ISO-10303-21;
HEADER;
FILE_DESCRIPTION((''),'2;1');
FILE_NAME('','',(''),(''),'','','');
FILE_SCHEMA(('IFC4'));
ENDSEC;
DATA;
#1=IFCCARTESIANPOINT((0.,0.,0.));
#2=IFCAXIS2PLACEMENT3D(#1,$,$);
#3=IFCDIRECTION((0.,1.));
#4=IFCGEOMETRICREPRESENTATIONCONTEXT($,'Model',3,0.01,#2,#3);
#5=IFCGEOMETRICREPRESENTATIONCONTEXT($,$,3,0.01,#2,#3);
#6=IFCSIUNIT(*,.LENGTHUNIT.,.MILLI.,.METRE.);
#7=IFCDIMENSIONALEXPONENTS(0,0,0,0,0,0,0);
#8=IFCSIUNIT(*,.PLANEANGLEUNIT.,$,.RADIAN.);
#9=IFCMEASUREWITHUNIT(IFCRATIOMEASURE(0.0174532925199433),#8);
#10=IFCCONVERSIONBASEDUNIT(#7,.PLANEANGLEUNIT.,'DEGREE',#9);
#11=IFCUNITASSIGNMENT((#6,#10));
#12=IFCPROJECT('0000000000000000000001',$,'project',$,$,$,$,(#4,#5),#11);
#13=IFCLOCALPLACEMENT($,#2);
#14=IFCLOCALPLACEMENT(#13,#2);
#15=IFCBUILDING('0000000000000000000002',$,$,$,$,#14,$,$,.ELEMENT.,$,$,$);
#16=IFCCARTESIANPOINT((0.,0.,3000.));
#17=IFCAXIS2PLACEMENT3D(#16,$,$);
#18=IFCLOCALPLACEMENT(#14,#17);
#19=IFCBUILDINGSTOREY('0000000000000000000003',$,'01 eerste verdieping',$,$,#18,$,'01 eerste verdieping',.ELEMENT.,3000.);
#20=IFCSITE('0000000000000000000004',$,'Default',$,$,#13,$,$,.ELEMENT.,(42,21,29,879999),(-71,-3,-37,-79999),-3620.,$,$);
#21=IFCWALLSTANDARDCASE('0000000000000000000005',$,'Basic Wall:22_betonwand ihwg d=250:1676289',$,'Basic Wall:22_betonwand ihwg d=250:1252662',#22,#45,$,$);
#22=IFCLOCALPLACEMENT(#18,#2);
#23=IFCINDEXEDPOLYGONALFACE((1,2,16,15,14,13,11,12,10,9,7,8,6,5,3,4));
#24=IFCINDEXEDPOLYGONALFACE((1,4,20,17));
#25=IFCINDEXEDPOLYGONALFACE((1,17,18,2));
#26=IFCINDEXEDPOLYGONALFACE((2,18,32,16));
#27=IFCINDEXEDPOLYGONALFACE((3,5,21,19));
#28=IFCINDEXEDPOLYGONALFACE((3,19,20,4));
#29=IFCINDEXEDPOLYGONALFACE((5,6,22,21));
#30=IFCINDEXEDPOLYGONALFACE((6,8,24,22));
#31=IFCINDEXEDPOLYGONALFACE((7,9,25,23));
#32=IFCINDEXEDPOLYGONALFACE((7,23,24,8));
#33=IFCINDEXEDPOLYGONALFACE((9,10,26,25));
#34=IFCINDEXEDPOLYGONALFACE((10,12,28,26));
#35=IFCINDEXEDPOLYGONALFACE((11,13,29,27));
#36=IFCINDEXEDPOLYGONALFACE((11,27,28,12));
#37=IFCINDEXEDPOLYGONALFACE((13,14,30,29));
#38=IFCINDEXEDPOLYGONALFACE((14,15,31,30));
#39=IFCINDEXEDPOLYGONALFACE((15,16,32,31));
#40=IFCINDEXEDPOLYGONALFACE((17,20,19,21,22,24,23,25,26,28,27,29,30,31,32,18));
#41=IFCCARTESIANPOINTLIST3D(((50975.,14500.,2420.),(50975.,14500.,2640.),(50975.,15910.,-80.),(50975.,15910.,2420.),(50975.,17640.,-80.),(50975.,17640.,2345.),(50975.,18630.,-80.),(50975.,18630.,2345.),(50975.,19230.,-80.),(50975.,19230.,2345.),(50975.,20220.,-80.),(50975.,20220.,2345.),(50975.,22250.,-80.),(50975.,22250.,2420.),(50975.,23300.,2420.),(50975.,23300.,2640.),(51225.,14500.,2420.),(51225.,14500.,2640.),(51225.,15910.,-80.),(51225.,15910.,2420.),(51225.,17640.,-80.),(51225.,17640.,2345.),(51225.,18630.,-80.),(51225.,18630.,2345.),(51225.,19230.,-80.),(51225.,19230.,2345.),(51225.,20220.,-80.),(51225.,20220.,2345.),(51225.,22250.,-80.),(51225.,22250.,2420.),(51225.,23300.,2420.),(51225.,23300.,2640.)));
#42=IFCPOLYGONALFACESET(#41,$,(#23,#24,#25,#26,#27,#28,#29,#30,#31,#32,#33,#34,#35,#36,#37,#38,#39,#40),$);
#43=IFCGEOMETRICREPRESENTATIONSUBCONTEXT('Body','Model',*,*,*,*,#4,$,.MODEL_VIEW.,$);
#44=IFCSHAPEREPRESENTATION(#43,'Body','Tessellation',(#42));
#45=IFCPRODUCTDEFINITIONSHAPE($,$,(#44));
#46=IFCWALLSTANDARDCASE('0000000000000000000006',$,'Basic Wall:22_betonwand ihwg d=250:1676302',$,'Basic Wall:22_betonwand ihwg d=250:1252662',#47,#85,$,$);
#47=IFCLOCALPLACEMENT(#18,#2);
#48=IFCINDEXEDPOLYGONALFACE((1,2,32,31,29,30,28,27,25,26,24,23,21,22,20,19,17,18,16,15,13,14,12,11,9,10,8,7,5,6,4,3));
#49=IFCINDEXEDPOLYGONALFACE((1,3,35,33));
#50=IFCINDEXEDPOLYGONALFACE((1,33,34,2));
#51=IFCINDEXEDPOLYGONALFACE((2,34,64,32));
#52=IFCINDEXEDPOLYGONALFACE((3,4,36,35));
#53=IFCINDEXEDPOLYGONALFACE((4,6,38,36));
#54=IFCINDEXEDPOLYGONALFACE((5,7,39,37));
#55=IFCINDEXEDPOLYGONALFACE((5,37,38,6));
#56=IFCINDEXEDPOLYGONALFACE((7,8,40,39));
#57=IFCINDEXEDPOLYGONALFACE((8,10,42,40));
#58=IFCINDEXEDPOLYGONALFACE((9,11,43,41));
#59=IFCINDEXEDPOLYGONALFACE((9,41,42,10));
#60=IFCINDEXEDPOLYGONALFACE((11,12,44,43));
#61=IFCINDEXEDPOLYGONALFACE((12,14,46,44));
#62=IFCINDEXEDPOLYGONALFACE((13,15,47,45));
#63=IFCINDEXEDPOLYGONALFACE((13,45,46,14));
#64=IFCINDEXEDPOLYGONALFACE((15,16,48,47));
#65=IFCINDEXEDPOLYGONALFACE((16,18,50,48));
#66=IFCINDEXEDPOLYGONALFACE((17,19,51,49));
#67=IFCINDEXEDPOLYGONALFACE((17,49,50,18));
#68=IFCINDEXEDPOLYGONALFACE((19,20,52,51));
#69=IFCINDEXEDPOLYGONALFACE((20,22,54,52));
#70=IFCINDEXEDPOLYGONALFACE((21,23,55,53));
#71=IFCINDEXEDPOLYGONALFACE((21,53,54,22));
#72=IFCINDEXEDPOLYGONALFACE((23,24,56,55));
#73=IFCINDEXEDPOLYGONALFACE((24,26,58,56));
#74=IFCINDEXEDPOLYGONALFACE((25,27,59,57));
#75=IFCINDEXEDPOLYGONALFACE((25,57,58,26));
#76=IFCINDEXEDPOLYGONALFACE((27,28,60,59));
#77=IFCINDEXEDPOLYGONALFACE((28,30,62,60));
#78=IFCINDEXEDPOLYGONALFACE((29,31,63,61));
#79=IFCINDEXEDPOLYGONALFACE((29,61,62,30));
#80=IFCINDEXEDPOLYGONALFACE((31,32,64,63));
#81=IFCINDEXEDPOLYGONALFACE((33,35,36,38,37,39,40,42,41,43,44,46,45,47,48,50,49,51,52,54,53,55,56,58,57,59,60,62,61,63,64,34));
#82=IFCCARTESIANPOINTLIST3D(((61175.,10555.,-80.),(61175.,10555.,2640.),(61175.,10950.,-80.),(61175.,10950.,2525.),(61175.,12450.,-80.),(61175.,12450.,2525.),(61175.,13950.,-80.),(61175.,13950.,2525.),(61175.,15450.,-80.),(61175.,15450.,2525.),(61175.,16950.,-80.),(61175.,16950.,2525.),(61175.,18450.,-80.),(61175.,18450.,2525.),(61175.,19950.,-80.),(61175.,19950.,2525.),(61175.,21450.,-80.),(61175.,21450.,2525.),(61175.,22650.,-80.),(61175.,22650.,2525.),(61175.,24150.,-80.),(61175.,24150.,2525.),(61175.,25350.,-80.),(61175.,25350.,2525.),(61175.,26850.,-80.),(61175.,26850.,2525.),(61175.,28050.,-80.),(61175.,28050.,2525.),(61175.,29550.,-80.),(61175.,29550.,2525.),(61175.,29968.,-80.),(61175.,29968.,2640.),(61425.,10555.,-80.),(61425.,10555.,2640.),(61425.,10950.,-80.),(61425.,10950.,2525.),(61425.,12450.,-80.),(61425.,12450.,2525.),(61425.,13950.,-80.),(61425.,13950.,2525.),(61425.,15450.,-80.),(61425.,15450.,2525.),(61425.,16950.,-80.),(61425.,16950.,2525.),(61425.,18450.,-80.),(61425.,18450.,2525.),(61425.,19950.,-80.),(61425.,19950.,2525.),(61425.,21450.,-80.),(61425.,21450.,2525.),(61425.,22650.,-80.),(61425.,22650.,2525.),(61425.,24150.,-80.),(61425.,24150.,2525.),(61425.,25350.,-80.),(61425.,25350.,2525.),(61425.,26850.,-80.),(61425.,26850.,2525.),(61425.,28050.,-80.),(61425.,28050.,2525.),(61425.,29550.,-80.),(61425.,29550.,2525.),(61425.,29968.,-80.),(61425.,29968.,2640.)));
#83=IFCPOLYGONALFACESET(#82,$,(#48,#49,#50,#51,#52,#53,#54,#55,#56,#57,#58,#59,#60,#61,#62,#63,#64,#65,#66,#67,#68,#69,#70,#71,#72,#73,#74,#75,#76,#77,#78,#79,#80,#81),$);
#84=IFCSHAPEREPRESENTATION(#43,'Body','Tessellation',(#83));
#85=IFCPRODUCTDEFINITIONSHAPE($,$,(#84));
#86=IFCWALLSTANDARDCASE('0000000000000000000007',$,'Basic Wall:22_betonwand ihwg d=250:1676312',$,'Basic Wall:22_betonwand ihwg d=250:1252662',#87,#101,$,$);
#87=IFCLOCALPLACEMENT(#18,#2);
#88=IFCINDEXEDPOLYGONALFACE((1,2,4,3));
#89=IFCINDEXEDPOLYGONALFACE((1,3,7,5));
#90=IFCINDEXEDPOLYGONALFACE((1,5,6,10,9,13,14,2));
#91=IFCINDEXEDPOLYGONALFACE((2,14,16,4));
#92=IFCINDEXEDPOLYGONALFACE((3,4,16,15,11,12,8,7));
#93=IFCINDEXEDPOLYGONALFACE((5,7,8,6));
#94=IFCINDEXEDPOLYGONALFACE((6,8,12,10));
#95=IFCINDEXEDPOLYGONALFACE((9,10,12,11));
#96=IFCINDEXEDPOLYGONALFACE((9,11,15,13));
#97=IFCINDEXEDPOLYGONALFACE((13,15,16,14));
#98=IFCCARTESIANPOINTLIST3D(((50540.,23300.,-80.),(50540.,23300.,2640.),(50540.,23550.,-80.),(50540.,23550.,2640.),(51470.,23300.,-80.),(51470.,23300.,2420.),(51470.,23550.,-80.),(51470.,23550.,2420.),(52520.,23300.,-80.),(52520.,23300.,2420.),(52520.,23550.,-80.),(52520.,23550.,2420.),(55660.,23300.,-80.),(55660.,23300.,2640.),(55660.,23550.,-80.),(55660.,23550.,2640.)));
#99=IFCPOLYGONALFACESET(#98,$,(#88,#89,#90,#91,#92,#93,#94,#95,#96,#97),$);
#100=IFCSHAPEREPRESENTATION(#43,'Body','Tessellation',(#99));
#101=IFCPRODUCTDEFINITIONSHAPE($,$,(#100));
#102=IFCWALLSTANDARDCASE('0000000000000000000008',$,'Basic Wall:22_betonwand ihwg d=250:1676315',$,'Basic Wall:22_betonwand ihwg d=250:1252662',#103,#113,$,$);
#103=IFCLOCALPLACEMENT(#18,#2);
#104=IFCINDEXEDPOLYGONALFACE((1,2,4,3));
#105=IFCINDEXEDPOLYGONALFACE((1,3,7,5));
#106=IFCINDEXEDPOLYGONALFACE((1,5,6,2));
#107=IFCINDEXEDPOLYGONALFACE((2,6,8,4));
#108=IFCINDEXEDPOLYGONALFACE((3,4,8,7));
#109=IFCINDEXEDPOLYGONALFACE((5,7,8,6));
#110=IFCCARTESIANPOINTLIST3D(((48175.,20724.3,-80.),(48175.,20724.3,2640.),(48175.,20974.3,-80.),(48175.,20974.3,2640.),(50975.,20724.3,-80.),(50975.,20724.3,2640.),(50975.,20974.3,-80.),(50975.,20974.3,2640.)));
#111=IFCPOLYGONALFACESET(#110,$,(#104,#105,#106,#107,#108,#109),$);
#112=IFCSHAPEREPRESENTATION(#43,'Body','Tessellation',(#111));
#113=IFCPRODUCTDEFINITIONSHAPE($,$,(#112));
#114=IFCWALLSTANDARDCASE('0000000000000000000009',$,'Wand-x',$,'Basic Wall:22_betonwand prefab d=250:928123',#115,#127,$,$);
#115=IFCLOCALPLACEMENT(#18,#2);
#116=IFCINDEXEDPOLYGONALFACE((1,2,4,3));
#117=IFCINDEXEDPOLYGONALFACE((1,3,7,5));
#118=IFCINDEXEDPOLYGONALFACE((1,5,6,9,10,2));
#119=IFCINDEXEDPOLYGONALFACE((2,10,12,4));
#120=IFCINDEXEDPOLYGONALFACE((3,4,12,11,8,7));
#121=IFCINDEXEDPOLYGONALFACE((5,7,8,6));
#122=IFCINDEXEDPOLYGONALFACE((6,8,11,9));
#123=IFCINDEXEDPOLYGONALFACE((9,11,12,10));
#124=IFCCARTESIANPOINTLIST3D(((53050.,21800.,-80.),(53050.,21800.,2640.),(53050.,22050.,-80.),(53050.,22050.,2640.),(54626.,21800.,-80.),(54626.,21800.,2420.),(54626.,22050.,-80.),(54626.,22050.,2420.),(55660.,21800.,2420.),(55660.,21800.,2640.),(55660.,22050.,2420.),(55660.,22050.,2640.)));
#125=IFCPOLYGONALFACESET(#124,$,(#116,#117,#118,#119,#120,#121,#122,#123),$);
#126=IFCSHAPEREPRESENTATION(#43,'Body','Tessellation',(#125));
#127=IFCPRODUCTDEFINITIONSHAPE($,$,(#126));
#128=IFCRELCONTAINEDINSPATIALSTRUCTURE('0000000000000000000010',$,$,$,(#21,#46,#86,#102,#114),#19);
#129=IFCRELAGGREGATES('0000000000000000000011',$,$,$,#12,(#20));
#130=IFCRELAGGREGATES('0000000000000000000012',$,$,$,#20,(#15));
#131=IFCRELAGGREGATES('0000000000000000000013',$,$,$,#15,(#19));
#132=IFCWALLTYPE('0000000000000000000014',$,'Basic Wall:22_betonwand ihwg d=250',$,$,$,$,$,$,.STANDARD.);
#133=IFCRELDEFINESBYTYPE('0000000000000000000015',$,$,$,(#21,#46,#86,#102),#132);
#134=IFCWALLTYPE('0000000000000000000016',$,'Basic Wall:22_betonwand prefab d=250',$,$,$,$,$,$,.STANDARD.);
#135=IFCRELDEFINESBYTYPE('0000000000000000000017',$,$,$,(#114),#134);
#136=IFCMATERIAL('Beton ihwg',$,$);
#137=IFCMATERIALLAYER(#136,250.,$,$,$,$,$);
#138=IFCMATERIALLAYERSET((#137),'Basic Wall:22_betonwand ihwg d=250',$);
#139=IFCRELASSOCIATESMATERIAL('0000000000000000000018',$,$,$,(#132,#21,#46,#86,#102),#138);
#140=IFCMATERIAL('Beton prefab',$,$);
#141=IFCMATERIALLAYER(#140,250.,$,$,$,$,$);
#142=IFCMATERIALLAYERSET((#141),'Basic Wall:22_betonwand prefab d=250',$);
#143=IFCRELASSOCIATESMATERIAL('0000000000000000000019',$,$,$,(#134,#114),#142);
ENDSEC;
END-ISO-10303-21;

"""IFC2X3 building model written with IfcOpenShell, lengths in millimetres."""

from ifc_helpers import new_model, entity, si_unit, converted_unit, direction, frame, frame_2d, origin, origin_2d_with_axis, place, context, subcontext, project, spatial, rectangle, extrude, material, layer, layer_set, layer_usage, type_object, element, save


model = new_model("IFC2X3")

# Units and contexts
model_context = context("Model", 3, precision=0.01, world=origin(), true_north=direction((0.0, 1.0)))
context_of_model = context(None, 3, precision=0.01, world=origin(), true_north=direction((0.0, 1.0)))
body_context = subcontext(model_context, "Body", "Model", "MODEL_VIEW")
ifc_project = project(units=[si_unit("LENGTHUNIT", "METRE", prefix="MILLI"), converted_unit("PLANEANGLEUNIT", "DEGREE", entity("IfcRatioMeasure", 0.0174532925199433), si_unit("PLANEANGLEUNIT", "RADIAN"), dimensions=[0, 0, 0, 0, 0, 0, 0])], contexts=[model_context, context_of_model])

# Site, building, storey
site_placement = place(None, origin())
site = spatial("IfcSite", under=ifc_project, at=site_placement, Name="Default", CompositionType="ELEMENT", RefLatitude=(42, 21, 29, 879999), RefLongitude=(-71, -3, -37, -79999), RefElevation=-3620.0)
building_placement = place(site_placement, origin())
building = spatial("IfcBuilding", under=site, at=building_placement, CompositionType="ELEMENT")
storey_placement = place(building_placement, frame((0.0, 0.0, 3000.0)))
storey = spatial("IfcBuildingStorey", under=building, at=storey_placement, Name="01 eerste verdieping", LongName="01 eerste verdieping", CompositionType="ELEMENT", Elevation=3000.0)

# Shared definitions
ifc_material_1 = material(Name="Beton prefab")

# Walls, openings
ifc_material_2 = material(Name="Beton ihwg")
ifc_layer_1 = layer(ifc_material_2, 250.0)
ifc_layer_set_1 = layer_set([ifc_layer_1], Name="Basic Wall:22_betonwand ihwg d=250")
ifc_layer_usage_1 = layer_usage(ifc_layer_set_1, "AXIS2", "NEGATIVE", 125.0)
wall_type_1 = type_object("IfcWallType", Name="Basic Wall:22_betonwand ihwg d=250", PredefinedType="STANDARD", material=ifc_layer_set_1)
wall_1_placement = place(storey_placement, frame((51100.0, 23300.0, -80.0), z_axis=(0.0, 0.0, 1.0), x_axis=(0.0, -1.0, 0.0)))
wall_1 = element("IfcWallStandardCase", 1, at=wall_1_placement, inside=storey, type_object=wall_type_1, material=ifc_layer_usage_1, Name="Basic Wall:22_betonwand ihwg d=250:1676289", ObjectType="Basic Wall:22_betonwand ihwg d=250:1252662", context=body_context, shape_type="SweptSolid", body=[
    extrude(rectangle(XDim=8800.0, YDim=250.0, at=frame_2d((4400.0, 0.0), x_axis=(-1.0, 0.0))), origin(), (0.0, 0.0, 1.0), 2720.0),
])
opening_1_placement = place(wall_1_placement, frame((23300.0, -51100.0, 80.0), z_axis=(0.0, 0.0, 1.0), x_axis=(0.0, 1.0, 0.0)))
element("IfcOpeningElement", 2, at=opening_1_placement, cuts=wall_1, ObjectType="Opening", context=body_context, shape_type="SweptSolid", body=[
    extrude(rectangle(XDim=2500.0, YDim=1410.0, at=frame_2d((0.0, 0.0), x_axis=(0.0, 1.0))), frame((50700.0, 15205.0, 1170.0), z_axis=(1.0, 0.0, 0.0), x_axis=(0.0, -1.0, 0.0)), (0.0, 0.0, 1.0), 800.0),
])
opening_2_placement = place(wall_1_placement, frame((23300.0, -51100.0, 80.0), z_axis=(0.0, 0.0, 1.0), x_axis=(0.0, 1.0, 0.0)))
element("IfcOpeningElement", 3, at=opening_2_placement, cuts=wall_1, ObjectType="Opening", context=body_context, shape_type="SweptSolid", body=[
    extrude(rectangle(XDim=2425.0, YDim=990.0, at=frame_2d((0.0, 0.0), x_axis=(1.0, 0.0))), frame((50700.0, 19725.0, 1132.5), z_axis=(1.0, 0.0, 0.0), x_axis=(0.0, 0.0, -1.0)), (0.0, 0.0, 1.0), 800.0),
])
opening_3_placement = place(wall_1_placement, frame((23300.0, -51100.0, 80.0), z_axis=(0.0, 0.0, 1.0), x_axis=(0.0, 1.0, 0.0)))
element("IfcOpeningElement", 4, at=opening_3_placement, cuts=wall_1, ObjectType="Opening", context=body_context, shape_type="SweptSolid", body=[
    extrude(rectangle(XDim=2425.0, YDim=990.0, at=origin_2d_with_axis()), frame((50700.0, 18135.0, 1132.5), z_axis=(1.0, 0.0, 0.0), x_axis=(0.0, 0.0, -1.0)), (0.0, 0.0, 1.0), 800.0),
])
opening_4_placement = place(wall_1_placement, frame((23300.0, -51100.0, 80.0), z_axis=(0.0, 0.0, 1.0), x_axis=(0.0, 1.0, 0.0)))
element("IfcOpeningElement", 5, at=opening_4_placement, cuts=wall_1, ObjectType="Opening", context=body_context, shape_type="SweptSolid", body=[
    extrude(rectangle(XDim=2500.0, YDim=1050.0, at=frame_2d((0.0, 0.0), x_axis=(1.0, 0.0))), frame((50700.0, 22775.0, 1170.0), z_axis=(1.0, 0.0, 0.0), x_axis=(0.0, 0.0, -1.0)), (0.0, 0.0, 1.0), 800.0),
])
ifc_layer_usage_2 = layer_usage(ifc_layer_set_1, "AXIS2", "POSITIVE", -125.0)
wall_2_placement = place(storey_placement, frame((61300.0, 29968.0, -80.0), z_axis=(0.0, 0.0, 1.0), x_axis=(0.0, -1.0, 0.0)))
wall_2 = element("IfcWallStandardCase", 6, at=wall_2_placement, inside=storey, type_object=wall_type_1, material=ifc_layer_usage_2, Name="Basic Wall:22_betonwand ihwg d=250:1676302", ObjectType="Basic Wall:22_betonwand ihwg d=250:1252662", context=body_context, shape_type="SweptSolid", body=[
    extrude(rectangle(XDim=19413.0, YDim=250.0, at=frame_2d((9706.5, 0.0), x_axis=(-1.0, 0.0))), origin(), (0.0, 0.0, 1.0), 2720.0),
])
opening_5_placement = place(wall_2_placement, frame((29968.0, -61300.0, 80.0), z_axis=(0.0, 0.0, 1.0), x_axis=(0.0, 1.0, 0.0)))
element("IfcOpeningElement", 7, at=opening_5_placement, cuts=wall_2, ObjectType="Opening", context=body_context, shape_type="SweptSolid", body=[
    extrude(rectangle(XDim=2605.0, YDim=1500.0, at=frame_2d((0.0, 0.0), x_axis=(1.0, 0.0))), frame((59901.0, 28800.0, 1222.5), z_axis=(1.0, 0.0, 0.0), x_axis=(0.0, 0.0, -1.0)), (0.0, 0.0, 1.0), 3048.0),
])
opening_6_placement = place(wall_2_placement, frame((29968.0, -61300.0, 80.0), z_axis=(0.0, 0.0, 1.0), x_axis=(0.0, 1.0, 0.0)))
element("IfcOpeningElement", 8, at=opening_6_placement, cuts=wall_2, ObjectType="Opening", context=body_context, shape_type="SweptSolid", body=[
    extrude(rectangle(XDim=2605.0, YDim=1500.0, at=frame_2d((0.0, 0.0), x_axis=(1.0, 0.0))), frame((59901.0, 26100.0, 1222.5), z_axis=(1.0, 0.0, 0.0), x_axis=(0.0, 0.0, -1.0)), (0.0, 0.0, 1.0), 3048.0),
])
opening_7_placement = place(wall_2_placement, frame((29968.0, -61300.0, 80.0), z_axis=(0.0, 0.0, 1.0), x_axis=(0.0, 1.0, 0.0)))
element("IfcOpeningElement", 9, at=opening_7_placement, cuts=wall_2, ObjectType="Opening", context=body_context, shape_type="SweptSolid", body=[
    extrude(rectangle(XDim=2605.0, YDim=1500.0, at=frame_2d((0.0, 0.0), x_axis=(1.0, 0.0))), frame((59901.0, 23400.0, 1222.5), z_axis=(1.0, 0.0, 0.0), x_axis=(0.0, 0.0, -1.0)), (0.0, 0.0, 1.0), 3048.0),
])
opening_8_placement = place(wall_2_placement, frame((29968.0, -61300.0, 80.0), z_axis=(0.0, 0.0, 1.0), x_axis=(0.0, 1.0, 0.0)))
element("IfcOpeningElement", 10, at=opening_8_placement, cuts=wall_2, ObjectType="Opening", context=body_context, shape_type="SweptSolid", body=[
    extrude(rectangle(XDim=2605.0, YDim=1500.0, at=frame_2d((0.0, 0.0), x_axis=(1.0, 0.0))), frame((59901.0, 17700.0, 1222.5), z_axis=(1.0, 0.0, 0.0), x_axis=(0.0, 0.0, -1.0)), (0.0, 0.0, 1.0), 3048.0),
])
opening_9_placement = place(wall_2_placement, frame((29968.0, -61300.0, 80.0), z_axis=(0.0, 0.0, 1.0), x_axis=(0.0, 1.0, 0.0)))
element("IfcOpeningElement", 11, at=opening_9_placement, cuts=wall_2, ObjectType="Opening", context=body_context, shape_type="SweptSolid", body=[
    extrude(rectangle(XDim=2605.0, YDim=1500.0, at=frame_2d((0.0, 0.0), x_axis=(1.0, 0.0))), frame((59901.0, 14700.0, 1222.5), z_axis=(1.0, 0.0, 0.0), x_axis=(0.0, 0.0, -1.0)), (0.0, 0.0, 1.0), 3048.0),
])
opening_10_placement = place(wall_2_placement, frame((29968.0, -61300.0, 80.0), z_axis=(0.0, 0.0, 1.0), x_axis=(0.0, 1.0, 0.0)))
element("IfcOpeningElement", 12, at=opening_10_placement, cuts=wall_2, ObjectType="Opening", context=body_context, shape_type="SweptSolid", body=[
    extrude(rectangle(XDim=2605.0, YDim=1500.0, at=frame_2d((0.0, 0.0), x_axis=(1.0, 0.0))), frame((59901.0, 20700.0, 1222.5), z_axis=(1.0, 0.0, 0.0), x_axis=(0.0, 0.0, -1.0)), (0.0, 0.0, 1.0), 3048.0),
])
opening_11_placement = place(wall_2_placement, frame((29968.0, -61300.0, 80.0), z_axis=(0.0, 0.0, 1.0), x_axis=(0.0, 1.0, 0.0)))
element("IfcOpeningElement", 13, at=opening_11_placement, cuts=wall_2, ObjectType="Opening", context=body_context, shape_type="SweptSolid", body=[
    extrude(rectangle(XDim=2605.0, YDim=1500.0, at=frame_2d((0.0, 0.0), x_axis=(1.0, 0.0))), frame((59901.0, 11700.0, 1222.5), z_axis=(1.0, 0.0, 0.0), x_axis=(0.0, 0.0, -1.0)), (0.0, 0.0, 1.0), 3048.0),
])
ifc_layer_usage_3 = layer_usage(ifc_layer_set_1, "AXIS2", "POSITIVE", -125.0)
wall_3_placement = place(storey_placement, frame((55660.0, 23425.0, -80.0), z_axis=(0.0, 0.0, 1.0), x_axis=(-1.0, 0.0, 0.0)))
wall_3 = element("IfcWallStandardCase", 14, at=wall_3_placement, inside=storey, type_object=wall_type_1, material=ifc_layer_usage_3, Name="Basic Wall:22_betonwand ihwg d=250:1676312", ObjectType="Basic Wall:22_betonwand ihwg d=250:1252662", context=body_context, shape_type="SweptSolid", body=[
    extrude(rectangle(XDim=5120.0, YDim=250.0, at=frame_2d((2560.0, 0.0), x_axis=(-1.0, 0.0))), origin(), (0.0, 0.0, 1.0), 2720.0),
])
opening_12_placement = place(wall_3_placement, origin())
element("IfcOpeningElement", 15, at=opening_12_placement, cuts=wall_3, ObjectType="Opening", context=body_context, shape_type="SweptSolid", body=[
    extrude(rectangle(XDim=2500.0, YDim=800.0, at=frame_2d((0.0, 0.0), x_axis=(0.0, 1.0))), frame((2735.0, 125.0, 1250.0), z_axis=(0.0, 1.0, 0.0), x_axis=(-1.0, 0.0, 0.0)), (0.0, 0.0, 1.0), 1034.0),
])
opening_13_placement = place(wall_3_placement, origin())
element("IfcOpeningElement", 16, at=opening_13_placement, cuts=wall_3, ObjectType="Opening", context=body_context, shape_type="SweptSolid", body=[
    extrude(rectangle(XDim=2500.0, YDim=800.0, at=frame_2d((0.0, 0.0), x_axis=(0.0, 1.0))), frame((4560.0, 125.0, 1250.0), z_axis=(0.0, 1.0, 0.0), x_axis=(1.0, 0.0, 0.0)), (0.0, 0.0, 1.0), 1050.0),
])
opening_14_placement = place(wall_3_placement, frame((55660.0, 23425.0, 80.0), z_axis=(0.0, 0.0, 1.0), x_axis=(-1.0, 0.0, 0.0)))
element("IfcOpeningElement", 17, at=opening_14_placement, cuts=wall_3, ObjectType="Opening", context=body_context, shape_type="SweptSolid", body=[
    extrude(rectangle(XDim=2500.0, YDim=1050.0, at=frame_2d((0.0, 0.0), x_axis=(0.0, 1.0))), frame((51995.0, 23825.0, 1170.0), z_axis=(0.0, -1.0, 0.0), x_axis=(-1.0, 0.0, 0.0)), (0.0, 0.0, 1.0), 800.0),
])

# Wall
ifc_layer_usage_4 = layer_usage(ifc_layer_set_1, "AXIS2", "POSITIVE", -125.0)
wall_4_placement = place(storey_placement, frame((50975.0, 20849.3, -80.0), z_axis=(0.0, 0.0, 1.0), x_axis=(-1.0, 0.0, 0.0)))
element("IfcWallStandardCase", 18, at=wall_4_placement, inside=storey, type_object=wall_type_1, material=ifc_layer_usage_4, Name="Basic Wall:22_betonwand ihwg d=250:1676315", ObjectType="Basic Wall:22_betonwand ihwg d=250:1252662", context=body_context, shape_type="SweptSolid", body=[
    extrude(rectangle(XDim=2800.0, YDim=250.0, at=frame_2d((1400.0, 0.0), x_axis=(-1.0, 0.0))), origin(), (0.0, 0.0, 1.0), 2720.0),
])

# Wall, opening
ifc_layer_2 = layer(ifc_material_1, 250.0)
ifc_layer_set_2 = layer_set([ifc_layer_2], Name="Basic Wall:22_betonwand prefab d=250")
ifc_layer_usage_5 = layer_usage(ifc_layer_set_2, "AXIS2", "NEGATIVE", 125.0)
wall_type_2 = type_object("IfcWallType", Name="Basic Wall:22_betonwand prefab d=250", PredefinedType="STANDARD", material=ifc_layer_set_2)
wall_5_placement = place(storey_placement, frame((53050.0, 21925.0, -80.0)))
wall_5 = element("IfcWallStandardCase", 19, at=wall_5_placement, inside=storey, type_object=wall_type_2, material=ifc_layer_usage_5, Name="Wand-x", ObjectType="Basic Wall:22_betonwand prefab d=250:928123", context=body_context, shape_type="SweptSolid", body=[
    extrude(rectangle(XDim=2610.0, YDim=250.0, at=frame_2d((1305.0, 0.0), x_axis=(-1.0, 0.0))), origin(), (0.0, 0.0, 1.0), 2720.0),
])
opening_15_placement = place(wall_5_placement, frame((-53050.0, -21925.0, 80.0)))
element("IfcOpeningElement", 20, at=opening_15_placement, cuts=wall_5, ObjectType="Opening", context=body_context, shape_type="SweptSolid", body=[
    extrude(rectangle(XDim=2500.0, YDim=1034.0, at=frame_2d((0.0, 0.0), x_axis=(1.0, 0.0))), frame((55143.0, 21525.0, 1170.0), z_axis=(0.0, 1.0, 0.0), x_axis=(0.0, 0.0, -1.0)), (0.0, 0.0, 1.0), 800.0),
])

save(model, "model.ifc")
